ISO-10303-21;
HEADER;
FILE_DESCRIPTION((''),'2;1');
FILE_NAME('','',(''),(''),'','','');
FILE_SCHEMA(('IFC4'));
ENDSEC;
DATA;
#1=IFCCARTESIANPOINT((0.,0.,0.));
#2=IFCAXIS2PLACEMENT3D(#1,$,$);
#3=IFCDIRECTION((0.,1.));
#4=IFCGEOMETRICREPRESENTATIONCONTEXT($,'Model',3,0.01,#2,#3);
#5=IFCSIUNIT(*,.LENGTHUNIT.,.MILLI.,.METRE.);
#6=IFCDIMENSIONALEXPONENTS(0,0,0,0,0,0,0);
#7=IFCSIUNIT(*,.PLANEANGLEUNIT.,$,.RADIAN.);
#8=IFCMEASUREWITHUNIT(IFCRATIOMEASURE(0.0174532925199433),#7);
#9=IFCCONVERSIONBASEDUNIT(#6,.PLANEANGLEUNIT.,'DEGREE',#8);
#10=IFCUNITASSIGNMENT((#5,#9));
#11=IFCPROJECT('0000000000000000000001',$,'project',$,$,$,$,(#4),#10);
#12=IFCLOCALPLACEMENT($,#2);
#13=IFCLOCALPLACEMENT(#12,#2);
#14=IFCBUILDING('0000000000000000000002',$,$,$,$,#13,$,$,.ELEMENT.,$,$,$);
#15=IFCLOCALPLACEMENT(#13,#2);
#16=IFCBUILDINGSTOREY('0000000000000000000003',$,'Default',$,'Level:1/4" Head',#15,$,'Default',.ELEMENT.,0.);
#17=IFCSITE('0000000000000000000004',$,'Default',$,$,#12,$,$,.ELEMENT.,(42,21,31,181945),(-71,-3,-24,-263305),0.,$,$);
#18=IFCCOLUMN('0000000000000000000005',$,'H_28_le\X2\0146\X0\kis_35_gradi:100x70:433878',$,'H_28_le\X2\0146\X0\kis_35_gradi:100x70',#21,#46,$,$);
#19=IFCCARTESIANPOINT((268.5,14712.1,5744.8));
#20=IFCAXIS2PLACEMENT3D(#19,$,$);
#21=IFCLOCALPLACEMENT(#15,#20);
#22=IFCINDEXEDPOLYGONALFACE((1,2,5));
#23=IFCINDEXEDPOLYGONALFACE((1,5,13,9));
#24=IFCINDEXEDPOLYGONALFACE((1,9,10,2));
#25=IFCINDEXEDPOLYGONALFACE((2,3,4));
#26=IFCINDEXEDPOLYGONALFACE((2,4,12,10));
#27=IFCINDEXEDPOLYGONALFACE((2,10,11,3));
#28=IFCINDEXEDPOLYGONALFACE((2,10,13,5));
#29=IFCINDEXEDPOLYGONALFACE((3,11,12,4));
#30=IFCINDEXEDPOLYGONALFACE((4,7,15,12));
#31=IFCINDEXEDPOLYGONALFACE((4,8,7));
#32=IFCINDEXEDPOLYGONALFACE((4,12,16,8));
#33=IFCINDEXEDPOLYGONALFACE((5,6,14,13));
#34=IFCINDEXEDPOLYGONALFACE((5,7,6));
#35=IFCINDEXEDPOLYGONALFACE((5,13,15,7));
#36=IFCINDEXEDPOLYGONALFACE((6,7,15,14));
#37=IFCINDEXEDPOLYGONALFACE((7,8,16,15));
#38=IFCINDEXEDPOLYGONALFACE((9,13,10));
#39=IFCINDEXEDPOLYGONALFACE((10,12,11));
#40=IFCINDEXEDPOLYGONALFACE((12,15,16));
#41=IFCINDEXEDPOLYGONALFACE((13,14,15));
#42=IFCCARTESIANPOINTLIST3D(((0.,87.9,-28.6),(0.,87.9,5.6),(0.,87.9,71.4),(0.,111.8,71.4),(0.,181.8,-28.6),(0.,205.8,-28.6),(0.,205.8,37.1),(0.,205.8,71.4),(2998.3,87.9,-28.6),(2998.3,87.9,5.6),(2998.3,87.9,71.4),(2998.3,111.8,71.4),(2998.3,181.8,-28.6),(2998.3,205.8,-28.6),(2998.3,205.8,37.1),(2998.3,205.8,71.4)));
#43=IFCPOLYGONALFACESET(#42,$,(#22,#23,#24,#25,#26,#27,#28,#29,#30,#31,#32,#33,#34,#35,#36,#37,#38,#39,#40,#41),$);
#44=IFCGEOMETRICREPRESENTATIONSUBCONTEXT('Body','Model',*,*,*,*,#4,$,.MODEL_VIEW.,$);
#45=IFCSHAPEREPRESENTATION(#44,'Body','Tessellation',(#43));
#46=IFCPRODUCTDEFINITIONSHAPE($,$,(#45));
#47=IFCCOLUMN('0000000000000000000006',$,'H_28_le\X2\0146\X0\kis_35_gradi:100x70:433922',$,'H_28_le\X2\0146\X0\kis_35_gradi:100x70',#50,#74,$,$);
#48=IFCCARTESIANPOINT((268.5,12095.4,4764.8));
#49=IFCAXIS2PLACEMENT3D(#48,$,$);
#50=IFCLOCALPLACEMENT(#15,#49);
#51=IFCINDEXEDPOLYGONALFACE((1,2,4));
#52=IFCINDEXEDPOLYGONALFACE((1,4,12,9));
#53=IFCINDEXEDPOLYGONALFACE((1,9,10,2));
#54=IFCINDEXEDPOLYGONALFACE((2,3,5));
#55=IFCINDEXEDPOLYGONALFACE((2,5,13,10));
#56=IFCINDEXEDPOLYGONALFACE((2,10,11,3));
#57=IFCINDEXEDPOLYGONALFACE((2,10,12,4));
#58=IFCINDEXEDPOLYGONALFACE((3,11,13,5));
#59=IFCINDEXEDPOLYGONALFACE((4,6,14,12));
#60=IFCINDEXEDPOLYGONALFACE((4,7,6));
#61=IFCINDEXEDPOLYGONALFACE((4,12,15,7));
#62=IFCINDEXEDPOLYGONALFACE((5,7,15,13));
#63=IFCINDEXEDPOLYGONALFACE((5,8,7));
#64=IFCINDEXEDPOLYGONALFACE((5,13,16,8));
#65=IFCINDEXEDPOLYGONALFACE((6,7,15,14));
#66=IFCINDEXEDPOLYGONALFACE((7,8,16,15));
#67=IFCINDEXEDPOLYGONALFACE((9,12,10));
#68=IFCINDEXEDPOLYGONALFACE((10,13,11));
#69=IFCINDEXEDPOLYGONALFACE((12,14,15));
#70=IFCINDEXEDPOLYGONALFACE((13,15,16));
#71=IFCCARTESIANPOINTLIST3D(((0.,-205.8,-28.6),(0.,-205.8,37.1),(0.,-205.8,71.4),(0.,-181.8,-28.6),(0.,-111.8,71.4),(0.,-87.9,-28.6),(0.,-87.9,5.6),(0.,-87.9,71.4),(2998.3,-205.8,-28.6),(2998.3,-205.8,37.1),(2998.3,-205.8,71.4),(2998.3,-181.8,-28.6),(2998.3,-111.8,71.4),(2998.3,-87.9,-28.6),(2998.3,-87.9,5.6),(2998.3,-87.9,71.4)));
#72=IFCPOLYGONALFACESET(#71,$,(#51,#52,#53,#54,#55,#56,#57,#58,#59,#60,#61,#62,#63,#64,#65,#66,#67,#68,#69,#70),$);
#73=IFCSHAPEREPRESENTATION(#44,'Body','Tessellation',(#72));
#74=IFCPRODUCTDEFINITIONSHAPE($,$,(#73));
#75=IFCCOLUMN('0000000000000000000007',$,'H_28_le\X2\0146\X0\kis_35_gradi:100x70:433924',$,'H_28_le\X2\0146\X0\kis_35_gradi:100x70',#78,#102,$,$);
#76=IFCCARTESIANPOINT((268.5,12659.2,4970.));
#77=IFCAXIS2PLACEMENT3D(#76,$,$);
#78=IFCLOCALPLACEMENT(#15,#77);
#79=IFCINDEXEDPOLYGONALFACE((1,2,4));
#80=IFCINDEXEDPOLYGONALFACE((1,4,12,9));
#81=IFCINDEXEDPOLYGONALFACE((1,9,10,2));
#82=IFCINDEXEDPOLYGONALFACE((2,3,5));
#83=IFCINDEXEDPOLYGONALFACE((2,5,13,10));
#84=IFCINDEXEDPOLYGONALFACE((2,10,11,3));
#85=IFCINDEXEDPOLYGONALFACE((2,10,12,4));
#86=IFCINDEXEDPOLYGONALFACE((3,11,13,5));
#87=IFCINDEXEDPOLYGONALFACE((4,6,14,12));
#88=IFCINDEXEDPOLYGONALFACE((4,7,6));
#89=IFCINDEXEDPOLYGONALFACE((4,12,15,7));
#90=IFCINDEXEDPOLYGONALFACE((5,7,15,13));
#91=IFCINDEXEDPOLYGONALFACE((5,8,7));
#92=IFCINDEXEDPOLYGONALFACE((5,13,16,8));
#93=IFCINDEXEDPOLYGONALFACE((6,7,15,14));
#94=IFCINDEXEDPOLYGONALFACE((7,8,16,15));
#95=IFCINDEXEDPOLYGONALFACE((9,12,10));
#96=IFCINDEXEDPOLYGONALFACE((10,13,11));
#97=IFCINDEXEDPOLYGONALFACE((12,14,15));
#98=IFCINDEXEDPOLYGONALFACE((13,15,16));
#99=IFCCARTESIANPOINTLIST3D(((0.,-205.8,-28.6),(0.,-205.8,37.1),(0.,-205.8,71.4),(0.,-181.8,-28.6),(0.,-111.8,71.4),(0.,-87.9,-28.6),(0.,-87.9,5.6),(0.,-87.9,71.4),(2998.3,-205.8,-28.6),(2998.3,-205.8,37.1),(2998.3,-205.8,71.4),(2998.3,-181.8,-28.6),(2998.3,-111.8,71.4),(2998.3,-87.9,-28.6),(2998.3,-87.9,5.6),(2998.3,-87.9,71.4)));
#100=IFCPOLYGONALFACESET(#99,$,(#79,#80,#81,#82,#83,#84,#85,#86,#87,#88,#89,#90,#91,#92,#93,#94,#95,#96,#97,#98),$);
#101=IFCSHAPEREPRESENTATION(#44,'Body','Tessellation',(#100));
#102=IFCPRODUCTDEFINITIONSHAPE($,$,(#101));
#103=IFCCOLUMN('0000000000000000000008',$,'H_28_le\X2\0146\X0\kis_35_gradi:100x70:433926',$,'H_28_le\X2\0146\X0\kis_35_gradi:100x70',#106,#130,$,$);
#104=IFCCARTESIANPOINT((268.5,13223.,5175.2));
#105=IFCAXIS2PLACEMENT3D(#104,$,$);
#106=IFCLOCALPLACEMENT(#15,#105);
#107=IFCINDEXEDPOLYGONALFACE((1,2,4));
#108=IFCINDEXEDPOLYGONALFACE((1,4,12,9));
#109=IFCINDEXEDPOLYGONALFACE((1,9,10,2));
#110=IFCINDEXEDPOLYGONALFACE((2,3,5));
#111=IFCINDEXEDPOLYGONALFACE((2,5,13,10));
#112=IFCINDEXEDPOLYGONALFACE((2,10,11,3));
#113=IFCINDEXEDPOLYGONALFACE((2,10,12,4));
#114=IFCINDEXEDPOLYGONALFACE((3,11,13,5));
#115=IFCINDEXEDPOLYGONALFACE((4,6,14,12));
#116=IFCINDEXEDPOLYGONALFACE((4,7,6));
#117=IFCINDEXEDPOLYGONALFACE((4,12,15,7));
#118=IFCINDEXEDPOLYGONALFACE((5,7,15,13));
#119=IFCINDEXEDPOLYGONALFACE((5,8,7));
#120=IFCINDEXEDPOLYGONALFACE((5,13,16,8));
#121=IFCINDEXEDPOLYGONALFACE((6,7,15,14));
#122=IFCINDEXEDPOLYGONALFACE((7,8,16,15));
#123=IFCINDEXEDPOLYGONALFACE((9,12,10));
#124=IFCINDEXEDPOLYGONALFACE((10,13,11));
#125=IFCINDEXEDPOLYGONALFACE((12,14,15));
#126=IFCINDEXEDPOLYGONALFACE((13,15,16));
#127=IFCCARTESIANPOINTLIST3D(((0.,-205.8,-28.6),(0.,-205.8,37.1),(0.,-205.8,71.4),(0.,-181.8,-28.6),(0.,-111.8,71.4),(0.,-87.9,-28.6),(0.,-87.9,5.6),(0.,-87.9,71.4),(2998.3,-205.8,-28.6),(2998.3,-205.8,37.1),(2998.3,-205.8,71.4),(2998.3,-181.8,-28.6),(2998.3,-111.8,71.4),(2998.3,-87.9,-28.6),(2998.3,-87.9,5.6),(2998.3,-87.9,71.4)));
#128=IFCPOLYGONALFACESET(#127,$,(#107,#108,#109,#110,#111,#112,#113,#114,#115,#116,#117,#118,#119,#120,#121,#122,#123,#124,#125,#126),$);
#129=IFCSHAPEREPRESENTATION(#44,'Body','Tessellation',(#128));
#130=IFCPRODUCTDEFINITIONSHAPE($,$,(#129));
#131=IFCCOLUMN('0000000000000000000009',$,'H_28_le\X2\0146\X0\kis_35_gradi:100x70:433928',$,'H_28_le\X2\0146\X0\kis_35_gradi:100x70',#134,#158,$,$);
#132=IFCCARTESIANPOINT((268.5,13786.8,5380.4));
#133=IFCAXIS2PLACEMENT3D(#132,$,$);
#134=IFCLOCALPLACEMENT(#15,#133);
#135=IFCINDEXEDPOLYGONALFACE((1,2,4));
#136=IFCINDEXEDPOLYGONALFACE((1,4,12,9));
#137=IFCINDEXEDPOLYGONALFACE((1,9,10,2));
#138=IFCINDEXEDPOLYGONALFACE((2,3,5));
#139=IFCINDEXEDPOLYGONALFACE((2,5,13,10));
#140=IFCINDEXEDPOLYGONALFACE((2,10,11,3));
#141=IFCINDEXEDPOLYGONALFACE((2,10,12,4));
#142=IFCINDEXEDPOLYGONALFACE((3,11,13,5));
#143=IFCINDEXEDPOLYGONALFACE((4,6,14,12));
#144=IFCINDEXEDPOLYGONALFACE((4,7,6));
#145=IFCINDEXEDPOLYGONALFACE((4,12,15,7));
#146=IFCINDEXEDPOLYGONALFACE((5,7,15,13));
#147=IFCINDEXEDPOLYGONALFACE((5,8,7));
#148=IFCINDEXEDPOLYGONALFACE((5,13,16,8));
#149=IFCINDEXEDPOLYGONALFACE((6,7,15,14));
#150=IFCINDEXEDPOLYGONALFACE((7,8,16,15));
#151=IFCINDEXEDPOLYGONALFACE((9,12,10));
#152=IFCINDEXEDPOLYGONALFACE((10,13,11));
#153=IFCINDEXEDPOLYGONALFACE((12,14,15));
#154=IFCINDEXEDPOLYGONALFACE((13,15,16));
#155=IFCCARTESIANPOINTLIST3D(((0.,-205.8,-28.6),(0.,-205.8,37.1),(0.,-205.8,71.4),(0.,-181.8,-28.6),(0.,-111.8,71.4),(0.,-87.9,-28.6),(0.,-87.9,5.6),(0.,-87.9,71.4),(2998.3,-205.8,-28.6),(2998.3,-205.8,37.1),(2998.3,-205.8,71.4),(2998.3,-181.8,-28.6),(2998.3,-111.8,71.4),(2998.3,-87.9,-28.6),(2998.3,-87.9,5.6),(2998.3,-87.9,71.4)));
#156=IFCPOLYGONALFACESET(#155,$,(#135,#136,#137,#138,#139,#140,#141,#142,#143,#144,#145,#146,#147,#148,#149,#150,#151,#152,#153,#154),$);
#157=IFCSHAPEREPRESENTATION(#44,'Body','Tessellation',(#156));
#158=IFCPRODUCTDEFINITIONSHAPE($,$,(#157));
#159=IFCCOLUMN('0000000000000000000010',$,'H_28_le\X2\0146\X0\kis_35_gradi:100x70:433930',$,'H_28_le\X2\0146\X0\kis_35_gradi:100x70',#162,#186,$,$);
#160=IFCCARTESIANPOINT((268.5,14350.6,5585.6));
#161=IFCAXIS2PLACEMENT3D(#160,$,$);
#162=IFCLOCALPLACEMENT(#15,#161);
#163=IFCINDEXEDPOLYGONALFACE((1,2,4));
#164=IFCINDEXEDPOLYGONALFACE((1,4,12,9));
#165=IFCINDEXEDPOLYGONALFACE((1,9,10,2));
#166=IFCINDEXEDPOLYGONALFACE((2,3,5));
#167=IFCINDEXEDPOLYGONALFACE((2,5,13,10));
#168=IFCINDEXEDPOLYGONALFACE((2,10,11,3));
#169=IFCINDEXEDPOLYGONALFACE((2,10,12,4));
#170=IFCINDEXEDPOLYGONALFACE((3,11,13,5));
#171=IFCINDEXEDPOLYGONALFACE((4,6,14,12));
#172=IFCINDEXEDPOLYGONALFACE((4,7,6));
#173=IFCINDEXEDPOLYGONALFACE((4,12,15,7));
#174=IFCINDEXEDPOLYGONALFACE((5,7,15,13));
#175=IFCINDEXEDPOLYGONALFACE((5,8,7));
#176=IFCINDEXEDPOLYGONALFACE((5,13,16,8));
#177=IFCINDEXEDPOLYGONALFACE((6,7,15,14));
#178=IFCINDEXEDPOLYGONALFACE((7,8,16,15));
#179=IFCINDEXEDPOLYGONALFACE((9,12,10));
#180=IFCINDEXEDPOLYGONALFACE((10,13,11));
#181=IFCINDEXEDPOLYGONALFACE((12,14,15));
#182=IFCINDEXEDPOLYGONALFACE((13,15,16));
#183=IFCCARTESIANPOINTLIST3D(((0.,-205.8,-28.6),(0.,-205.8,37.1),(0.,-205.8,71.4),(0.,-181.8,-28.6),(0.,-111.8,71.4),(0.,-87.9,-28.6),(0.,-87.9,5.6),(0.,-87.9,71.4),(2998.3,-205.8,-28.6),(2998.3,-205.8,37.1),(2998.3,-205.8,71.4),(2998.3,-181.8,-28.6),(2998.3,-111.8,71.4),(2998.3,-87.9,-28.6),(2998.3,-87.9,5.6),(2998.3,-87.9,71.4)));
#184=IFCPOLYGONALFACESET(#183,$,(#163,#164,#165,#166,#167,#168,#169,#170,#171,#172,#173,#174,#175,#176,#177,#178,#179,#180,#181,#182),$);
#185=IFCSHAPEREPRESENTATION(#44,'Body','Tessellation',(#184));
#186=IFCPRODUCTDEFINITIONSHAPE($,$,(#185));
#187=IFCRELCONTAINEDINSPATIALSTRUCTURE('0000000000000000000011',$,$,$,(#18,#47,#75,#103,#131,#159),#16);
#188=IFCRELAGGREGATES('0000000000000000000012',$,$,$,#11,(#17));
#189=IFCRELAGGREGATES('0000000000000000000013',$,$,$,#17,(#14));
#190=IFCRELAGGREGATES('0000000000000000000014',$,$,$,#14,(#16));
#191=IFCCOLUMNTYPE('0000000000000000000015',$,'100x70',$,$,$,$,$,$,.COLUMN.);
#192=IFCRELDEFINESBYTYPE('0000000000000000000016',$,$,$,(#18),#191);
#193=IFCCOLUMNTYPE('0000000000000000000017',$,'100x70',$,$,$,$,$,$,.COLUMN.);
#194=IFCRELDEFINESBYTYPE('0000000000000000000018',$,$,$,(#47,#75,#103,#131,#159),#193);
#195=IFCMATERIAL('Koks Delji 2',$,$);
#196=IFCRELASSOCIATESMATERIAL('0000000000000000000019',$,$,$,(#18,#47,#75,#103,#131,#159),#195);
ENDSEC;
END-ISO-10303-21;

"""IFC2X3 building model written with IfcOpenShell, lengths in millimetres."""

from ifc_helpers import new_model, entity, si_unit, converted_unit, direction, frame, frame_2d, origin, place, context, subcontext, project, spatial, rectangle, extrude, boolean, source, transform, mapped, material, type_object, type_shapes, element, save


model = new_model("IFC2X3")

# Units and contexts
model_context = context("Model", 3, precision=0.01, world=origin(), true_north=direction((0.0, 1.0)))
body_context = subcontext(model_context, "Body", "Model", "MODEL_VIEW")
ifc_project = project(units=[si_unit("LENGTHUNIT", "METRE", prefix="MILLI"), converted_unit("PLANEANGLEUNIT", "DEGREE", entity("IfcRatioMeasure", 0.0174532925199433), si_unit("PLANEANGLEUNIT", "RADIAN"), dimensions=[0, 0, 0, 0, 0, 0, 0])], contexts=[model_context])

# Site, building, storey
site_placement = place(None, origin())
site = spatial("IfcSite", under=ifc_project, at=site_placement, Name="Default", CompositionType="ELEMENT", RefLatitude=(42, 21, 31, 181945), RefLongitude=(-71, -3, -24, -263305), RefElevation=0.0)
building_placement = place(site_placement, origin())
building = spatial("IfcBuilding", under=site, at=building_placement, CompositionType="ELEMENT")
storey_placement = place(building_placement, origin())
storey = spatial("IfcBuildingStorey", under=building, at=storey_placement, Name="Default", ObjectType="Level:1/4\" Head", LongName="Default", CompositionType="ELEMENT", Elevation=0.0)

# Columns
ifc_material_1 = material(Name="Koks Delji 2")
column_type_1 = type_object("IfcColumnType", Name="100x70", PredefinedType="COLUMN")
shared_shape_1 = source(origin(), body_context, "Body", "CSG", [
    boolean("DIFFERENCE", extrude(rectangle(XDim=2998.3, YDim=117.9, at=frame_2d((0.0, 0.0), x_axis=(1.0, 0.0))), frame((1499.1, 146.8, -28.6)), (0.0, 0.0, 1.0), 100.0), extrude(rectangle(XDim=70.0, YDim=100.0, at=frame_2d((0.0, 0.0), x_axis=(0.0, 1.0))), frame((2998.3, 146.8, 21.4), z_axis=(1.0, 0.0, 0.0), x_axis=(0.0, 0.939693, -0.34202)), (0.0, 0.0, -1.0), 2998.3)),
])
type_shapes(column_type_1, [shared_shape_1])
column_placement = place(storey_placement, frame((268.5, 14712.1, 5744.8)))
element("IfcColumn", 1, at=column_placement, inside=storey, type_object=column_type_1, material=ifc_material_1, Name="H_28_leņkis_35_gradi:100x70:433878", ObjectType="H_28_leņkis_35_gradi:100x70", context=body_context, shape_type="MappedRepresentation", body=[
    mapped(shared_shape_1, transform((0.0, 0.0, 0.0), scale=1.0)),
])
column_type_2 = type_object("IfcColumnType", Name="100x70", PredefinedType="COLUMN")
shared_shape_2 = source(origin(), body_context, "Body", "CSG", [
    boolean("DIFFERENCE", extrude(rectangle(XDim=2998.3, YDim=117.9, at=frame_2d((0.0, 0.0), x_axis=(1.0, 0.0))), frame((1499.1, -146.8, -28.6)), (0.0, 0.0, 1.0), 100.0), extrude(rectangle(XDim=70.0, YDim=100.0, at=frame_2d((0.0, 0.0), x_axis=(0.0, 1.0))), frame((0.0, -146.8, 21.4), z_axis=(-1.0, 0.0, 0.0), x_axis=(0.0, -0.939693, -0.34202)), (0.0, 0.0, -1.0), 2998.3)),
])
type_shapes(column_type_2, [shared_shape_2])
for number, where, name in (
    (2, (268.5, 12095.4, 4764.8), "H_28_leņkis_35_gradi:100x70:433922"),
    (3, (268.5, 12659.2, 4970.0), "H_28_leņkis_35_gradi:100x70:433924"),
    (4, (268.5, 13223.0, 5175.2), "H_28_leņkis_35_gradi:100x70:433926"),
    (5, (268.5, 13786.8, 5380.4), "H_28_leņkis_35_gradi:100x70:433928"),
    (6, (268.5, 14350.6, 5585.6), "H_28_leņkis_35_gradi:100x70:433930"),
):
    element("IfcColumn", number, at=place(storey_placement, frame(where)), inside=storey, type_object=column_type_2, material=ifc_material_1, Name=name, ObjectType="H_28_leņkis_35_gradi:100x70", context=body_context, shape_type="MappedRepresentation", body=[
        mapped(shared_shape_2, transform((0.0, 0.0, 0.0), scale=1.0)),
    ])

save(model, "model.ifc")
